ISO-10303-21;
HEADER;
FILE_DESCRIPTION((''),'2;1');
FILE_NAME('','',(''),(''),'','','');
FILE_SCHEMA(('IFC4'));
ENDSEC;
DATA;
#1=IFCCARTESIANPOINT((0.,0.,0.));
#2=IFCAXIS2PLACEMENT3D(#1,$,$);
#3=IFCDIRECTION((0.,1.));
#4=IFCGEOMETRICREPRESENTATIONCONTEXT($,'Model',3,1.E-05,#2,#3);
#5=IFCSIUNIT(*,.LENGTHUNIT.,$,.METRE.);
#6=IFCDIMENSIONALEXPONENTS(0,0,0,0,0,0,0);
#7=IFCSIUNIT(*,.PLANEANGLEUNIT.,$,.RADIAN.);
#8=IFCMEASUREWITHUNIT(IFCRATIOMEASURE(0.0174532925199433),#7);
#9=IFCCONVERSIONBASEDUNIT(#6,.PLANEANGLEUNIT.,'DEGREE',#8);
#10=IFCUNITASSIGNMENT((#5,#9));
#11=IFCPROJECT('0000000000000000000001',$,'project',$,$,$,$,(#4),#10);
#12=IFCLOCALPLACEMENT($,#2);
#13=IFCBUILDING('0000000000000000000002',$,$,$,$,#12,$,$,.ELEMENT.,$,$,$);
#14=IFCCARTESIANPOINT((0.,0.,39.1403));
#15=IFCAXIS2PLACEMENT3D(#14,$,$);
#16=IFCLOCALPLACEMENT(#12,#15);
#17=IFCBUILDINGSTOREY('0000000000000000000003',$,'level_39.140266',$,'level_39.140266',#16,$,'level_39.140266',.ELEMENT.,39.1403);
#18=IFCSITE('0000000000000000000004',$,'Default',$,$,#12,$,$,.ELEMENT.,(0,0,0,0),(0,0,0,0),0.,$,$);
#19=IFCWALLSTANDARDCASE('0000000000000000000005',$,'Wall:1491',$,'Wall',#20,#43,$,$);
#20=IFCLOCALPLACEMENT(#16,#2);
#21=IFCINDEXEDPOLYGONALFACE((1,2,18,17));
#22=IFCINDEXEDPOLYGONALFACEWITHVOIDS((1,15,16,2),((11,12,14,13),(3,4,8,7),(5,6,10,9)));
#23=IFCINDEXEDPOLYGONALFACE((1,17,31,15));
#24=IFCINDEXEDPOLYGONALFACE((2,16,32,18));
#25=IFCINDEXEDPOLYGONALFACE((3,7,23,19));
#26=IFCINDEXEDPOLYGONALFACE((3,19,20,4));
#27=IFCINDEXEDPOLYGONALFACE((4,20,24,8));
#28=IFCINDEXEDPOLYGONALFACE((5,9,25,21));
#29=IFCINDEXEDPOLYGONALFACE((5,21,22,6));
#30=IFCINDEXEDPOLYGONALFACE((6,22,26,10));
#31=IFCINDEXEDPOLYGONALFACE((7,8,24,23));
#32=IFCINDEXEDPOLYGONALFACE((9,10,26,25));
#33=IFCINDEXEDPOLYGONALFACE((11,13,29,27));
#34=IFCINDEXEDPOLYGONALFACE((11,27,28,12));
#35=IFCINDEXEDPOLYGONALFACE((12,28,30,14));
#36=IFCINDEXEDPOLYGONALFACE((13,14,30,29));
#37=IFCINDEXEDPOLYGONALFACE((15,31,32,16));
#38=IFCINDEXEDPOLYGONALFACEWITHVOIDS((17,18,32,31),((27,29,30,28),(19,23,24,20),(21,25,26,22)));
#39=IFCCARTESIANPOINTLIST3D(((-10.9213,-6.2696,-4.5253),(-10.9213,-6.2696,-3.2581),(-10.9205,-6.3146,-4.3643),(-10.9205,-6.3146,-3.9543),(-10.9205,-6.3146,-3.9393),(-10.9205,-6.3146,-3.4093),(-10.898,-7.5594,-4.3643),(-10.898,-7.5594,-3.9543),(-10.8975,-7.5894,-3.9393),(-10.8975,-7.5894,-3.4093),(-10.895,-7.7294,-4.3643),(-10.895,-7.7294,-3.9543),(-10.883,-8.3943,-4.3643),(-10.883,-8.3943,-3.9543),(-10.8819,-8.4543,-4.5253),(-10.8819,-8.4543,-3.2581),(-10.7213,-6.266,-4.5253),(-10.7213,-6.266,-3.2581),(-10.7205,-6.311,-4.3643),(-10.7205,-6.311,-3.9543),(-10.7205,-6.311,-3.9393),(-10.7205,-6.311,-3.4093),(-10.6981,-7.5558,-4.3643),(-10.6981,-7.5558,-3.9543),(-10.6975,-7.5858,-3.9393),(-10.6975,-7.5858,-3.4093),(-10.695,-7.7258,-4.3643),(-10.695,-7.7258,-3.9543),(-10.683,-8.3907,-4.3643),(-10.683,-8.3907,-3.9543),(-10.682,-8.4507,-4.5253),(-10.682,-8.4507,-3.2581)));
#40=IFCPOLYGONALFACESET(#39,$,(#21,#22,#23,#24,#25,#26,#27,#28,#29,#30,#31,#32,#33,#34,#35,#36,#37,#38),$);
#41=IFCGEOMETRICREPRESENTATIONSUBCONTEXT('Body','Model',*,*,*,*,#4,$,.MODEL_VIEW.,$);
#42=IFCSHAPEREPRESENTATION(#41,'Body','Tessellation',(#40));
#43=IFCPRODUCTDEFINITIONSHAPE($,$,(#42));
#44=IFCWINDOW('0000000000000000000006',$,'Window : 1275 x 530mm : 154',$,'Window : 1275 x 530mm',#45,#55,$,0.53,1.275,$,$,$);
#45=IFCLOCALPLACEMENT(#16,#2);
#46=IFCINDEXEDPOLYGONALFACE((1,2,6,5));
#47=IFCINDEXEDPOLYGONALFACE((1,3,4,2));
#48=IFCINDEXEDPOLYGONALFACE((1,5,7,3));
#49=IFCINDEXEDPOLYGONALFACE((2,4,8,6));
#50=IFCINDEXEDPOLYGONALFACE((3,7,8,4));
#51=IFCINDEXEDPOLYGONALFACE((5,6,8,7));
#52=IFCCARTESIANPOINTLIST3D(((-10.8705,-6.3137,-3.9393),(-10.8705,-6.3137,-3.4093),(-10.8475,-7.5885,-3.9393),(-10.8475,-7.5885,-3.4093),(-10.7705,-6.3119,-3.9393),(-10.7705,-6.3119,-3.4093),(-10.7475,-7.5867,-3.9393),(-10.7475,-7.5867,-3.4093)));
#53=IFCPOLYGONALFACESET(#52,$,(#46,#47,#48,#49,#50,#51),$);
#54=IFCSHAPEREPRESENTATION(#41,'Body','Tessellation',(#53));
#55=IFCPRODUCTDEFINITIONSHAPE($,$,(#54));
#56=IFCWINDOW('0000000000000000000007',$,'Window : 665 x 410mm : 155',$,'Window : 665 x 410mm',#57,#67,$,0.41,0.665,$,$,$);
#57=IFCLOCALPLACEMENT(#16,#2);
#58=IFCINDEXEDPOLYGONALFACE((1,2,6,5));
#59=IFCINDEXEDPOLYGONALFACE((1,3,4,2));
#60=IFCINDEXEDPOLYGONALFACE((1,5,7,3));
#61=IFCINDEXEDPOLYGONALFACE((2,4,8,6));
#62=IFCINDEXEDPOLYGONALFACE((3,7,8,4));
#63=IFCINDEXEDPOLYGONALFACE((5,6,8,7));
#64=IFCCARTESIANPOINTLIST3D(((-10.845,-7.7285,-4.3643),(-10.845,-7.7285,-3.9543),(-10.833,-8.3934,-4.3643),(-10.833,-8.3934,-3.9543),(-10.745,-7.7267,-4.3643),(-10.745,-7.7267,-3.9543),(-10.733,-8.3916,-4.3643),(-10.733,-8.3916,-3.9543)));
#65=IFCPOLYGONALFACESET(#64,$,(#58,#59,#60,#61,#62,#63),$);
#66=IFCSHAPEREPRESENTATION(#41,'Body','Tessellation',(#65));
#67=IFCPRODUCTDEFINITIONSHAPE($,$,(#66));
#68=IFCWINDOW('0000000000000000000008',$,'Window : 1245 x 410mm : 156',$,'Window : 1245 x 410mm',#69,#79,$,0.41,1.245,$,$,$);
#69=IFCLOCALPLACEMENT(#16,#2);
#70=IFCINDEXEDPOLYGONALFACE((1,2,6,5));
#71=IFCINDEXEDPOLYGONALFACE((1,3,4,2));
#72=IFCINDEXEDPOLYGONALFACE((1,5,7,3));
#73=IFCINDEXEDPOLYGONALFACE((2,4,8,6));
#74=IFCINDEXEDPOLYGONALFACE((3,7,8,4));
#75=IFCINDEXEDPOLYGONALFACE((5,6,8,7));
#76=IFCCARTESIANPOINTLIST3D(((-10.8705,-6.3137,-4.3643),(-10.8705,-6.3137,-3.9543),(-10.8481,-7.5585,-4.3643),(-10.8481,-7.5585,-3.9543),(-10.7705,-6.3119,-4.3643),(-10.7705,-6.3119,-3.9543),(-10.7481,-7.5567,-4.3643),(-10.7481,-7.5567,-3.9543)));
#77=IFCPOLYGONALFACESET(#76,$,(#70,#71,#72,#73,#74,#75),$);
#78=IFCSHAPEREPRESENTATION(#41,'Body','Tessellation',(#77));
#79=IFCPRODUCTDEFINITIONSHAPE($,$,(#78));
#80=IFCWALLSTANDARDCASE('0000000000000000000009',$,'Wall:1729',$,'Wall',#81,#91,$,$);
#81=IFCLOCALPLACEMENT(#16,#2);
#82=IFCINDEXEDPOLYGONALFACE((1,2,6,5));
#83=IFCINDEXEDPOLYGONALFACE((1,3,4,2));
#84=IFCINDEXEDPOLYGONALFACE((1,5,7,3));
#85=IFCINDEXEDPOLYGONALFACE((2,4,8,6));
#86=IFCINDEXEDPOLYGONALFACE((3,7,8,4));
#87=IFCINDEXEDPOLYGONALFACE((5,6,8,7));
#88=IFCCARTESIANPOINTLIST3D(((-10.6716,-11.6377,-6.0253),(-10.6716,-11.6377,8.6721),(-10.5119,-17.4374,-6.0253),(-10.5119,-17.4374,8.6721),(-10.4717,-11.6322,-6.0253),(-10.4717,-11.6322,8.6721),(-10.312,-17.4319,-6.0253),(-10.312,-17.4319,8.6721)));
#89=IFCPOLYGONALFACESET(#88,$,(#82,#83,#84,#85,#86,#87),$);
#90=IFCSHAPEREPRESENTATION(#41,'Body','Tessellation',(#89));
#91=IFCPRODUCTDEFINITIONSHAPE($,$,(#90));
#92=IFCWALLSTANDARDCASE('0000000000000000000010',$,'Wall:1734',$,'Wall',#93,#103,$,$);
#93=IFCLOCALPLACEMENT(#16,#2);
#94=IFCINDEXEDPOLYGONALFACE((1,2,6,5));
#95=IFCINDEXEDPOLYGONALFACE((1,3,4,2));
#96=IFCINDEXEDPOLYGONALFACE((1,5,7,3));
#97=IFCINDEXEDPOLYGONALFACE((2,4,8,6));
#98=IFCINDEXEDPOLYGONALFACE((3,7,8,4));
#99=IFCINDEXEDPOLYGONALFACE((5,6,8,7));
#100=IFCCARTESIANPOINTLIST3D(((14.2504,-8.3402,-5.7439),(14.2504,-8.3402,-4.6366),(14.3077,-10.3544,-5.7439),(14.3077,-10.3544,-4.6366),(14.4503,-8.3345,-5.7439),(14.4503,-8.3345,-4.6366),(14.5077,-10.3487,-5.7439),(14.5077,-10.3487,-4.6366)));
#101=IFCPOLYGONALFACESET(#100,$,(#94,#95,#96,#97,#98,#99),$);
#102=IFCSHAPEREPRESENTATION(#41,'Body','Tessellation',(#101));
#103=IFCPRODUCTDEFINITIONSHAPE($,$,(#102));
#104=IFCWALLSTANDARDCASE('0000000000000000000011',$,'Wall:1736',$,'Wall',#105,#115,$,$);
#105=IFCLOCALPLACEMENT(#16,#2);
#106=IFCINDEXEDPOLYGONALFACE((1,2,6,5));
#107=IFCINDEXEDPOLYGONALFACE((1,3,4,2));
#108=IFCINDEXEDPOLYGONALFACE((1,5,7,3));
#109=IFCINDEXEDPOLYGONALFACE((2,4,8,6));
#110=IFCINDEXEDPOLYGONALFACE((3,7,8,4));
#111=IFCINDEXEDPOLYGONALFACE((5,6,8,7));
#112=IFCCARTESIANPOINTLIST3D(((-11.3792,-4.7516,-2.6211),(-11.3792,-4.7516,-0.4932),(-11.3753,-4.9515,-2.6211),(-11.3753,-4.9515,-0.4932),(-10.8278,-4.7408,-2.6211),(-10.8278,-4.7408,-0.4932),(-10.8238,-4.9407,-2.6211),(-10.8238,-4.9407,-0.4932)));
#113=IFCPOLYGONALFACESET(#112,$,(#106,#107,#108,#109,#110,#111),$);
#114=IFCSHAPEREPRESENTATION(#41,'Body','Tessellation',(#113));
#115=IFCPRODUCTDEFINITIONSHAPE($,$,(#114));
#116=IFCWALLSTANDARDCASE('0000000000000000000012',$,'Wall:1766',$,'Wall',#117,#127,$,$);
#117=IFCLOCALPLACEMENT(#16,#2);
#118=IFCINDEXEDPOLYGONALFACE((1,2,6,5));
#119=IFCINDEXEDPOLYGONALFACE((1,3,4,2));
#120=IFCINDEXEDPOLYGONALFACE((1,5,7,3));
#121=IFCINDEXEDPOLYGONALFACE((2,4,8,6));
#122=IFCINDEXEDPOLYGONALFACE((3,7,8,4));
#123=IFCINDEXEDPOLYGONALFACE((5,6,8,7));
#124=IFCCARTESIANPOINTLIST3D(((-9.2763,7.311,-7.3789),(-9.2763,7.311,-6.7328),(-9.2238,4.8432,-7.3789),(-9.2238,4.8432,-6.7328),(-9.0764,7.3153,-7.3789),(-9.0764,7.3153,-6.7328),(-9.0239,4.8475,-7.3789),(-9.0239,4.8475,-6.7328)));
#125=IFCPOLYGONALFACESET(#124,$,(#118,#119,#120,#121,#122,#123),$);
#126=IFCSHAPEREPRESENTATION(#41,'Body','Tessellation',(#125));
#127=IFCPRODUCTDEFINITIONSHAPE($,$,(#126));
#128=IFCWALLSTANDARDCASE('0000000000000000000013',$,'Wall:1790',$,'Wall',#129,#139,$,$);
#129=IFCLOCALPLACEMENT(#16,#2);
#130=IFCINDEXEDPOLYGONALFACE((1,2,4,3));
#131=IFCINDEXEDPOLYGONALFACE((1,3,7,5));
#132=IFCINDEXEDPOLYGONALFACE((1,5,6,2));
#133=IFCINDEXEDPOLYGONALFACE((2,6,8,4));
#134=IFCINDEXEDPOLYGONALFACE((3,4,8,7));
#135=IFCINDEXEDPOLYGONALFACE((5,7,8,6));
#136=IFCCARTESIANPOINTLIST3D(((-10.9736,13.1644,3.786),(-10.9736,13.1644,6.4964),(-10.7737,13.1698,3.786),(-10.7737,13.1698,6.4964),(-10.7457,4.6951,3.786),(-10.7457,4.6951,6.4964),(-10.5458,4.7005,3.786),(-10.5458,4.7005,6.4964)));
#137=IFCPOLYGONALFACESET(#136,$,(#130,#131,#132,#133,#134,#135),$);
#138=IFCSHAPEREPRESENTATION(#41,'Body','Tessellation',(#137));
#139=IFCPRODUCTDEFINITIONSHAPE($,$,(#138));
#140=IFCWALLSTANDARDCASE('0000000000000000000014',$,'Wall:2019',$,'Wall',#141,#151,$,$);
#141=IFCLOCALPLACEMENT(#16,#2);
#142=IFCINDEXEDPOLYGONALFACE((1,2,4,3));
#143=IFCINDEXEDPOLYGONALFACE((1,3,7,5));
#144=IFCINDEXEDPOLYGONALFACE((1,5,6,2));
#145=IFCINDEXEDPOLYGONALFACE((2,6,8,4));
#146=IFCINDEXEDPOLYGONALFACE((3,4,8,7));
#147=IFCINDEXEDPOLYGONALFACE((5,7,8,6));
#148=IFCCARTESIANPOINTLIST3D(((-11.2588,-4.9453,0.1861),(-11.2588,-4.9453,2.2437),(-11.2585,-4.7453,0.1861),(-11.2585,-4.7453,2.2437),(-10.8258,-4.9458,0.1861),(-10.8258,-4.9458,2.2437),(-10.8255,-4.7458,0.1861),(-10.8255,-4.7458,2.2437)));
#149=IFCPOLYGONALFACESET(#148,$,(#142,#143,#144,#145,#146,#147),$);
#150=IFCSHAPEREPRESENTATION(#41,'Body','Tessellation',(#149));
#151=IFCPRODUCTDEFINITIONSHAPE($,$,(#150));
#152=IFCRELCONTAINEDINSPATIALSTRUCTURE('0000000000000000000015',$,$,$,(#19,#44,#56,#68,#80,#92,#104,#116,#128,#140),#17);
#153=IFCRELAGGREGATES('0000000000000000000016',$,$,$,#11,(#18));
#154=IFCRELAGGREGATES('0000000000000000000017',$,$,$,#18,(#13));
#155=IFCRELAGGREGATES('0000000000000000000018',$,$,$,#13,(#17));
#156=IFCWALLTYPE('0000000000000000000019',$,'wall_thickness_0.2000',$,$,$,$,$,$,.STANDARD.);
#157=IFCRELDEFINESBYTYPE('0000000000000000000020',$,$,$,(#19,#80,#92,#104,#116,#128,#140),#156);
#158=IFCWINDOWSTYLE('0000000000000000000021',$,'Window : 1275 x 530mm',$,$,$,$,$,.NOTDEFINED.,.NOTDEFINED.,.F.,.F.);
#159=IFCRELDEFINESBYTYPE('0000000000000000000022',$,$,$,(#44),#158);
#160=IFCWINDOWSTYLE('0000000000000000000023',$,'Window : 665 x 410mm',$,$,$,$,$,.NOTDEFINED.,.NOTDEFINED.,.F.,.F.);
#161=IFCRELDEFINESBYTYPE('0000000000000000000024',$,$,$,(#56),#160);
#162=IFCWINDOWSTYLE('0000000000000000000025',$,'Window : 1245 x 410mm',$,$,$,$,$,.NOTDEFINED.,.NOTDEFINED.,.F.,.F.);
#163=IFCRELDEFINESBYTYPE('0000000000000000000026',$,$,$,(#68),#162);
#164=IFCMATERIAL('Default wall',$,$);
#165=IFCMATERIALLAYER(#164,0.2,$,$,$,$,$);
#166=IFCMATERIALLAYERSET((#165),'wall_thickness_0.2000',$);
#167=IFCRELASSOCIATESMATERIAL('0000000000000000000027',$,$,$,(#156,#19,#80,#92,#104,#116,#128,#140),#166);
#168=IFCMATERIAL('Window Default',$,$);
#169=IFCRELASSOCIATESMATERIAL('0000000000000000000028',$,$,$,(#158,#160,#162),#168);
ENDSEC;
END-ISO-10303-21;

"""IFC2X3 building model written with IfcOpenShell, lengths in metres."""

from ifc_helpers import new_model, entity, si_unit, converted_unit, direction, frame, frame_2d, origin, origin_2d_with_axis, place, context, subcontext, project, spatial, polyline, rectangle, outline, extrude, source, transform, mapped, material, layer, layer_set, layer_usage, type_object, type_shapes, element, fill, save


model = new_model("IFC2X3")

# Units and contexts
model_context = context("Model", 3, precision=1e-05, world=origin(), true_north=direction((0.0, 1.0)))
body_context = subcontext(model_context, "Body", "Model", "MODEL_VIEW")
ifc_project = project(units=[si_unit("LENGTHUNIT", "METRE"), converted_unit("PLANEANGLEUNIT", "DEGREE", entity("IfcRatioMeasure", 0.0174532925199433), si_unit("PLANEANGLEUNIT", "RADIAN"), dimensions=[0, 0, 0, 0, 0, 0, 0])], contexts=[model_context])

# Site, building, storey
placement_1 = place(None, origin())
site = spatial("IfcSite", under=ifc_project, at=placement_1, Name="Default", CompositionType="ELEMENT", RefLatitude=(0, 0, 0, 0), RefLongitude=(0, 0, 0, 0), RefElevation=0.0)
building = spatial("IfcBuilding", under=site, at=placement_1, CompositionType="ELEMENT")
storey_placement = place(placement_1, frame((0.0, 0.0, 39.1403)))
storey = spatial("IfcBuildingStorey", under=building, at=storey_placement, Name="level_39.140266", ObjectType="level_39.140266", LongName="level_39.140266", CompositionType="ELEMENT", Elevation=39.1403)

# Shared definitions
ifc_material_1 = material(Name="Default wall")
ifc_layer = layer(ifc_material_1, 0.2)
ifc_layer_set = layer_set([ifc_layer], Name="wall_thickness_0.2000")
ifc_layer_usage = layer_usage(ifc_layer_set, "AXIS2", "POSITIVE", -0.1)
wall_type = type_object("IfcWallType", Name="wall_thickness_0.2000", PredefinedType="STANDARD", material=ifc_layer_set)

# Wall, openings, windows
placement_2 = place(placement_1, frame((0.0, 0.0, 34.615)))
wall_1_placement = place(placement_2, frame((-10.7819, -8.4525, 0.0), z_axis=(0.0, 0.0, 1.0), x_axis=(-0.018001, 0.999838, 0.0)))
wall_1 = element("IfcWallStandardCase", 1, at=wall_1_placement, inside=storey, type_object=wall_type, material=ifc_layer_usage, Name="Wall:1491", ObjectType="Wall", context=body_context, shape_type="SweptSolid", body=[
    extrude(outline(polyline([(2.185, -0.1), (2.185, 0.1), (0.0, 0.1), (0.0, -0.1), (2.185, -0.1)])), origin(), (0.0, 0.0, 1.0), 1.2672),
])
opening_1_placement = place(wall_1_placement, frame((0.865, -0.1, 0.586)))
opening_1 = element("IfcOpeningElement", 2, at=opening_1_placement, cuts=wall_1, ObjectType="Opening", context=body_context, shape_type="SweptSolid", body=[
    extrude(rectangle(XDim=1.275, YDim=0.53, at=frame_2d((0.265, 0.6375), x_axis=(0.0, 1.0))), frame((0.0, 0.0, 0.0), z_axis=(0.0, 1.0, 0.0), x_axis=(0.0, 0.0, 1.0)), (0.0, 0.0, 1.0), 0.2),
])
opening_2_placement = place(wall_1_placement, frame((0.06, -0.1, 0.161)))
opening_2 = element("IfcOpeningElement", 3, at=opening_2_placement, cuts=wall_1, ObjectType="Opening", context=body_context, shape_type="SweptSolid", body=[
    extrude(rectangle(XDim=0.665, YDim=0.41, at=frame_2d((0.205, 0.3325), x_axis=(0.0, 1.0))), frame((0.0, 0.0, 0.0), z_axis=(0.0, 1.0, 0.0), x_axis=(0.0, 0.0, 1.0)), (0.0, 0.0, 1.0), 0.2),
])
opening_3_placement = place(wall_1_placement, frame((0.895, -0.1, 0.161)))
opening_3 = element("IfcOpeningElement", 4, at=opening_3_placement, cuts=wall_1, ObjectType="Opening", context=body_context, shape_type="SweptSolid", body=[
    extrude(rectangle(XDim=1.245, YDim=0.41, at=frame_2d((0.205, 0.6225), x_axis=(0.0, 1.0))), frame((0.0, 0.0, 0.0), z_axis=(0.0, 1.0, 0.0), x_axis=(0.0, 0.0, 1.0)), (0.0, 0.0, 1.0), 0.2),
])
ifc_material_2 = material(Name="Window Default")
window_style_1 = type_object("IfcWindowStyle", Name="Window : 1275 x 530mm", ConstructionType="NOTDEFINED", OperationType="NOTDEFINED", ParameterTakesPrecedence=False, Sizeable=False, material=ifc_material_2)
shared_shape_1 = source(origin(), body_context, "Body", "SweptSolid", [
    extrude(rectangle(XDim=0.1, YDim=1.275, at=origin_2d_with_axis()), frame((0.6375, 0.1, 0.0), z_axis=(0.0, 0.0, 1.0), x_axis=(0.0, 1.0, 0.0)), (0.0, 0.0, 1.0), 0.53),
])
type_shapes(window_style_1, [shared_shape_1])
window_1_placement = place(opening_1_placement, origin())
window_1 = element("IfcWindow", 5, at=window_1_placement, inside=storey, type_object=window_style_1, Name="Window : 1275 x 530mm : 154", ObjectType="Window : 1275 x 530mm", OverallHeight=0.53, OverallWidth=1.275, context=body_context, shape_type="MappedRepresentation", body=[
    mapped(shared_shape_1, transform((0.0, 0.0, 0.0), scale=1.0)),
])
fill(opening_1, window_1)
window_style_2 = type_object("IfcWindowStyle", Name="Window : 665 x 410mm", ConstructionType="NOTDEFINED", OperationType="NOTDEFINED", ParameterTakesPrecedence=False, Sizeable=False, material=ifc_material_2)
shared_shape_2 = source(origin(), body_context, "Body", "SweptSolid", [
    extrude(rectangle(XDim=0.1, YDim=0.665, at=origin_2d_with_axis()), frame((0.3325, 0.1, 0.0), z_axis=(0.0, 0.0, 1.0), x_axis=(0.0, 1.0, 0.0)), (0.0, 0.0, 1.0), 0.41),
])
type_shapes(window_style_2, [shared_shape_2])
window_2_placement = place(opening_2_placement, origin())
window_2 = element("IfcWindow", 6, at=window_2_placement, inside=storey, type_object=window_style_2, Name="Window : 665 x 410mm : 155", ObjectType="Window : 665 x 410mm", OverallHeight=0.41, OverallWidth=0.665, context=body_context, shape_type="MappedRepresentation", body=[
    mapped(shared_shape_2, transform((0.0, 0.0, 0.0), scale=1.0)),
])
fill(opening_2, window_2)
window_style_3 = type_object("IfcWindowStyle", Name="Window : 1245 x 410mm", ConstructionType="NOTDEFINED", OperationType="NOTDEFINED", ParameterTakesPrecedence=False, Sizeable=False, material=ifc_material_2)
shared_shape_3 = source(origin(), body_context, "Body", "SweptSolid", [
    extrude(rectangle(XDim=0.1, YDim=1.245, at=origin_2d_with_axis()), frame((0.6225, 0.1, 0.0), z_axis=(0.0, 0.0, 1.0), x_axis=(0.0, 1.0, 0.0)), (0.0, 0.0, 1.0), 0.41),
])
type_shapes(window_style_3, [shared_shape_3])
window_3_placement = place(opening_3_placement, origin())
window_3 = element("IfcWindow", 7, at=window_3_placement, inside=storey, type_object=window_style_3, Name="Window : 1245 x 410mm : 156", ObjectType="Window : 1245 x 410mm", OverallHeight=0.41, OverallWidth=1.245, context=body_context, shape_type="MappedRepresentation", body=[
    mapped(shared_shape_3, transform((0.0, 0.0, 0.0), scale=1.0)),
])
fill(opening_3, window_3)

# Walls
placement_3 = place(placement_1, frame((0.0, 0.0, 33.115)))
wall_2_placement = place(placement_3, frame((-10.5717, -11.6349, 0.0), z_axis=(0.0, 0.0, 1.0), x_axis=(0.027536, -0.999621, 0.0)))
element("IfcWallStandardCase", 8, at=wall_2_placement, inside=storey, type_object=wall_type, material=ifc_layer_usage, Name="Wall:1729", ObjectType="Wall", context=body_context, shape_type="SweptSolid", body=[
    extrude(outline(polyline([(5.8019, -0.1), (5.8019, 0.1), (0.0, 0.1), (0.0, -0.1), (5.8019, -0.1)])), origin(), (0.0, 0.0, 1.0), 14.6974),
])
placement_4 = place(placement_1, frame((0.0, 0.0, 33.3964)))
wall_3_placement = place(placement_4, frame((14.4077, -10.3516, 0.0), z_axis=(0.0, 0.0, 1.0), x_axis=(-0.028446, 0.999595, 0.0)))
element("IfcWallStandardCase", 9, at=wall_3_placement, inside=storey, type_object=wall_type, material=ifc_layer_usage, Name="Wall:1734", ObjectType="Wall", context=body_context, shape_type="SweptSolid", body=[
    extrude(outline(polyline([(2.015, -0.1), (2.015, 0.1), (0.0, 0.1), (0.0, -0.1), (2.015, -0.1)])), origin(), (0.0, 0.0, 1.0), 1.1073),
])
placement_5 = place(placement_1, frame((0.0, 0.0, 36.5192)))
wall_4_placement = place(placement_5, frame((-10.8258, -4.8407, 0.0), z_axis=(0.0, 0.0, 1.0), x_axis=(-0.999808, -0.019614, 0.0)))
element("IfcWallStandardCase", 10, at=wall_4_placement, inside=storey, type_object=wall_type, material=ifc_layer_usage, Name="Wall:1736", ObjectType="Wall", context=body_context, shape_type="SweptSolid", body=[
    extrude(outline(polyline([(0.5516, -0.1), (0.5516, 0.1), (0.0, 0.1), (0.0, -0.1), (0.5516, -0.1)])), origin(), (0.0, 0.0, 1.0), 2.1279),
])
placement_6 = place(placement_1, frame((0.0, 0.0, 31.7614)))
wall_5_placement = place(placement_6, frame((-9.1238, 4.8453, 0.0), z_axis=(0.0, 0.0, 1.0), x_axis=(-0.021266, 0.999774, 0.0)))
element("IfcWallStandardCase", 11, at=wall_5_placement, inside=storey, type_object=wall_type, material=ifc_layer_usage, Name="Wall:1766", ObjectType="Wall", context=body_context, shape_type="SweptSolid", body=[
    extrude(outline(polyline([(2.4684, -0.1), (2.4684, 0.1), (0.0, 0.1), (0.0, -0.1), (2.4684, -0.1)])), origin(), (0.0, 0.0, 1.0), 0.646),
])
placement_7 = place(placement_1, frame((0.0, 0.0, 42.9263)))
wall_6_placement = place(placement_7, frame((-10.6458, 4.6978, 0.0), z_axis=(0.0, 0.0, 1.0), x_axis=(-0.026895, 0.999638, 0.0)))
element("IfcWallStandardCase", 12, at=wall_6_placement, inside=storey, type_object=wall_type, material=ifc_layer_usage, Name="Wall:1790", ObjectType="Wall", context=body_context, shape_type="SweptSolid", body=[
    extrude(outline(polyline([(8.4724, -0.1), (8.4724, 0.1), (0.0, 0.1), (0.0, -0.1), (8.4724, -0.1)])), origin(), (0.0, 0.0, 1.0), 2.7104),
])
placement_8 = place(placement_1, frame((0.0, 0.0, 39.3264)))
wall_7_placement = place(placement_8, frame((-10.8257, -4.8458, 0.0), z_axis=(0.0, 0.0, 1.0), x_axis=(-0.999999, 0.001249, 0.0)))
element("IfcWallStandardCase", 13, at=wall_7_placement, inside=storey, type_object=wall_type, material=ifc_layer_usage, Name="Wall:2019", ObjectType="Wall", context=body_context, shape_type="SweptSolid", body=[
    extrude(outline(polyline([(0.433, -0.1), (0.433, 0.1), (0.0, 0.1), (0.0, -0.1), (0.433, -0.1)])), origin(), (0.0, 0.0, 1.0), 2.0575),
])

save(model, "model.ifc")
